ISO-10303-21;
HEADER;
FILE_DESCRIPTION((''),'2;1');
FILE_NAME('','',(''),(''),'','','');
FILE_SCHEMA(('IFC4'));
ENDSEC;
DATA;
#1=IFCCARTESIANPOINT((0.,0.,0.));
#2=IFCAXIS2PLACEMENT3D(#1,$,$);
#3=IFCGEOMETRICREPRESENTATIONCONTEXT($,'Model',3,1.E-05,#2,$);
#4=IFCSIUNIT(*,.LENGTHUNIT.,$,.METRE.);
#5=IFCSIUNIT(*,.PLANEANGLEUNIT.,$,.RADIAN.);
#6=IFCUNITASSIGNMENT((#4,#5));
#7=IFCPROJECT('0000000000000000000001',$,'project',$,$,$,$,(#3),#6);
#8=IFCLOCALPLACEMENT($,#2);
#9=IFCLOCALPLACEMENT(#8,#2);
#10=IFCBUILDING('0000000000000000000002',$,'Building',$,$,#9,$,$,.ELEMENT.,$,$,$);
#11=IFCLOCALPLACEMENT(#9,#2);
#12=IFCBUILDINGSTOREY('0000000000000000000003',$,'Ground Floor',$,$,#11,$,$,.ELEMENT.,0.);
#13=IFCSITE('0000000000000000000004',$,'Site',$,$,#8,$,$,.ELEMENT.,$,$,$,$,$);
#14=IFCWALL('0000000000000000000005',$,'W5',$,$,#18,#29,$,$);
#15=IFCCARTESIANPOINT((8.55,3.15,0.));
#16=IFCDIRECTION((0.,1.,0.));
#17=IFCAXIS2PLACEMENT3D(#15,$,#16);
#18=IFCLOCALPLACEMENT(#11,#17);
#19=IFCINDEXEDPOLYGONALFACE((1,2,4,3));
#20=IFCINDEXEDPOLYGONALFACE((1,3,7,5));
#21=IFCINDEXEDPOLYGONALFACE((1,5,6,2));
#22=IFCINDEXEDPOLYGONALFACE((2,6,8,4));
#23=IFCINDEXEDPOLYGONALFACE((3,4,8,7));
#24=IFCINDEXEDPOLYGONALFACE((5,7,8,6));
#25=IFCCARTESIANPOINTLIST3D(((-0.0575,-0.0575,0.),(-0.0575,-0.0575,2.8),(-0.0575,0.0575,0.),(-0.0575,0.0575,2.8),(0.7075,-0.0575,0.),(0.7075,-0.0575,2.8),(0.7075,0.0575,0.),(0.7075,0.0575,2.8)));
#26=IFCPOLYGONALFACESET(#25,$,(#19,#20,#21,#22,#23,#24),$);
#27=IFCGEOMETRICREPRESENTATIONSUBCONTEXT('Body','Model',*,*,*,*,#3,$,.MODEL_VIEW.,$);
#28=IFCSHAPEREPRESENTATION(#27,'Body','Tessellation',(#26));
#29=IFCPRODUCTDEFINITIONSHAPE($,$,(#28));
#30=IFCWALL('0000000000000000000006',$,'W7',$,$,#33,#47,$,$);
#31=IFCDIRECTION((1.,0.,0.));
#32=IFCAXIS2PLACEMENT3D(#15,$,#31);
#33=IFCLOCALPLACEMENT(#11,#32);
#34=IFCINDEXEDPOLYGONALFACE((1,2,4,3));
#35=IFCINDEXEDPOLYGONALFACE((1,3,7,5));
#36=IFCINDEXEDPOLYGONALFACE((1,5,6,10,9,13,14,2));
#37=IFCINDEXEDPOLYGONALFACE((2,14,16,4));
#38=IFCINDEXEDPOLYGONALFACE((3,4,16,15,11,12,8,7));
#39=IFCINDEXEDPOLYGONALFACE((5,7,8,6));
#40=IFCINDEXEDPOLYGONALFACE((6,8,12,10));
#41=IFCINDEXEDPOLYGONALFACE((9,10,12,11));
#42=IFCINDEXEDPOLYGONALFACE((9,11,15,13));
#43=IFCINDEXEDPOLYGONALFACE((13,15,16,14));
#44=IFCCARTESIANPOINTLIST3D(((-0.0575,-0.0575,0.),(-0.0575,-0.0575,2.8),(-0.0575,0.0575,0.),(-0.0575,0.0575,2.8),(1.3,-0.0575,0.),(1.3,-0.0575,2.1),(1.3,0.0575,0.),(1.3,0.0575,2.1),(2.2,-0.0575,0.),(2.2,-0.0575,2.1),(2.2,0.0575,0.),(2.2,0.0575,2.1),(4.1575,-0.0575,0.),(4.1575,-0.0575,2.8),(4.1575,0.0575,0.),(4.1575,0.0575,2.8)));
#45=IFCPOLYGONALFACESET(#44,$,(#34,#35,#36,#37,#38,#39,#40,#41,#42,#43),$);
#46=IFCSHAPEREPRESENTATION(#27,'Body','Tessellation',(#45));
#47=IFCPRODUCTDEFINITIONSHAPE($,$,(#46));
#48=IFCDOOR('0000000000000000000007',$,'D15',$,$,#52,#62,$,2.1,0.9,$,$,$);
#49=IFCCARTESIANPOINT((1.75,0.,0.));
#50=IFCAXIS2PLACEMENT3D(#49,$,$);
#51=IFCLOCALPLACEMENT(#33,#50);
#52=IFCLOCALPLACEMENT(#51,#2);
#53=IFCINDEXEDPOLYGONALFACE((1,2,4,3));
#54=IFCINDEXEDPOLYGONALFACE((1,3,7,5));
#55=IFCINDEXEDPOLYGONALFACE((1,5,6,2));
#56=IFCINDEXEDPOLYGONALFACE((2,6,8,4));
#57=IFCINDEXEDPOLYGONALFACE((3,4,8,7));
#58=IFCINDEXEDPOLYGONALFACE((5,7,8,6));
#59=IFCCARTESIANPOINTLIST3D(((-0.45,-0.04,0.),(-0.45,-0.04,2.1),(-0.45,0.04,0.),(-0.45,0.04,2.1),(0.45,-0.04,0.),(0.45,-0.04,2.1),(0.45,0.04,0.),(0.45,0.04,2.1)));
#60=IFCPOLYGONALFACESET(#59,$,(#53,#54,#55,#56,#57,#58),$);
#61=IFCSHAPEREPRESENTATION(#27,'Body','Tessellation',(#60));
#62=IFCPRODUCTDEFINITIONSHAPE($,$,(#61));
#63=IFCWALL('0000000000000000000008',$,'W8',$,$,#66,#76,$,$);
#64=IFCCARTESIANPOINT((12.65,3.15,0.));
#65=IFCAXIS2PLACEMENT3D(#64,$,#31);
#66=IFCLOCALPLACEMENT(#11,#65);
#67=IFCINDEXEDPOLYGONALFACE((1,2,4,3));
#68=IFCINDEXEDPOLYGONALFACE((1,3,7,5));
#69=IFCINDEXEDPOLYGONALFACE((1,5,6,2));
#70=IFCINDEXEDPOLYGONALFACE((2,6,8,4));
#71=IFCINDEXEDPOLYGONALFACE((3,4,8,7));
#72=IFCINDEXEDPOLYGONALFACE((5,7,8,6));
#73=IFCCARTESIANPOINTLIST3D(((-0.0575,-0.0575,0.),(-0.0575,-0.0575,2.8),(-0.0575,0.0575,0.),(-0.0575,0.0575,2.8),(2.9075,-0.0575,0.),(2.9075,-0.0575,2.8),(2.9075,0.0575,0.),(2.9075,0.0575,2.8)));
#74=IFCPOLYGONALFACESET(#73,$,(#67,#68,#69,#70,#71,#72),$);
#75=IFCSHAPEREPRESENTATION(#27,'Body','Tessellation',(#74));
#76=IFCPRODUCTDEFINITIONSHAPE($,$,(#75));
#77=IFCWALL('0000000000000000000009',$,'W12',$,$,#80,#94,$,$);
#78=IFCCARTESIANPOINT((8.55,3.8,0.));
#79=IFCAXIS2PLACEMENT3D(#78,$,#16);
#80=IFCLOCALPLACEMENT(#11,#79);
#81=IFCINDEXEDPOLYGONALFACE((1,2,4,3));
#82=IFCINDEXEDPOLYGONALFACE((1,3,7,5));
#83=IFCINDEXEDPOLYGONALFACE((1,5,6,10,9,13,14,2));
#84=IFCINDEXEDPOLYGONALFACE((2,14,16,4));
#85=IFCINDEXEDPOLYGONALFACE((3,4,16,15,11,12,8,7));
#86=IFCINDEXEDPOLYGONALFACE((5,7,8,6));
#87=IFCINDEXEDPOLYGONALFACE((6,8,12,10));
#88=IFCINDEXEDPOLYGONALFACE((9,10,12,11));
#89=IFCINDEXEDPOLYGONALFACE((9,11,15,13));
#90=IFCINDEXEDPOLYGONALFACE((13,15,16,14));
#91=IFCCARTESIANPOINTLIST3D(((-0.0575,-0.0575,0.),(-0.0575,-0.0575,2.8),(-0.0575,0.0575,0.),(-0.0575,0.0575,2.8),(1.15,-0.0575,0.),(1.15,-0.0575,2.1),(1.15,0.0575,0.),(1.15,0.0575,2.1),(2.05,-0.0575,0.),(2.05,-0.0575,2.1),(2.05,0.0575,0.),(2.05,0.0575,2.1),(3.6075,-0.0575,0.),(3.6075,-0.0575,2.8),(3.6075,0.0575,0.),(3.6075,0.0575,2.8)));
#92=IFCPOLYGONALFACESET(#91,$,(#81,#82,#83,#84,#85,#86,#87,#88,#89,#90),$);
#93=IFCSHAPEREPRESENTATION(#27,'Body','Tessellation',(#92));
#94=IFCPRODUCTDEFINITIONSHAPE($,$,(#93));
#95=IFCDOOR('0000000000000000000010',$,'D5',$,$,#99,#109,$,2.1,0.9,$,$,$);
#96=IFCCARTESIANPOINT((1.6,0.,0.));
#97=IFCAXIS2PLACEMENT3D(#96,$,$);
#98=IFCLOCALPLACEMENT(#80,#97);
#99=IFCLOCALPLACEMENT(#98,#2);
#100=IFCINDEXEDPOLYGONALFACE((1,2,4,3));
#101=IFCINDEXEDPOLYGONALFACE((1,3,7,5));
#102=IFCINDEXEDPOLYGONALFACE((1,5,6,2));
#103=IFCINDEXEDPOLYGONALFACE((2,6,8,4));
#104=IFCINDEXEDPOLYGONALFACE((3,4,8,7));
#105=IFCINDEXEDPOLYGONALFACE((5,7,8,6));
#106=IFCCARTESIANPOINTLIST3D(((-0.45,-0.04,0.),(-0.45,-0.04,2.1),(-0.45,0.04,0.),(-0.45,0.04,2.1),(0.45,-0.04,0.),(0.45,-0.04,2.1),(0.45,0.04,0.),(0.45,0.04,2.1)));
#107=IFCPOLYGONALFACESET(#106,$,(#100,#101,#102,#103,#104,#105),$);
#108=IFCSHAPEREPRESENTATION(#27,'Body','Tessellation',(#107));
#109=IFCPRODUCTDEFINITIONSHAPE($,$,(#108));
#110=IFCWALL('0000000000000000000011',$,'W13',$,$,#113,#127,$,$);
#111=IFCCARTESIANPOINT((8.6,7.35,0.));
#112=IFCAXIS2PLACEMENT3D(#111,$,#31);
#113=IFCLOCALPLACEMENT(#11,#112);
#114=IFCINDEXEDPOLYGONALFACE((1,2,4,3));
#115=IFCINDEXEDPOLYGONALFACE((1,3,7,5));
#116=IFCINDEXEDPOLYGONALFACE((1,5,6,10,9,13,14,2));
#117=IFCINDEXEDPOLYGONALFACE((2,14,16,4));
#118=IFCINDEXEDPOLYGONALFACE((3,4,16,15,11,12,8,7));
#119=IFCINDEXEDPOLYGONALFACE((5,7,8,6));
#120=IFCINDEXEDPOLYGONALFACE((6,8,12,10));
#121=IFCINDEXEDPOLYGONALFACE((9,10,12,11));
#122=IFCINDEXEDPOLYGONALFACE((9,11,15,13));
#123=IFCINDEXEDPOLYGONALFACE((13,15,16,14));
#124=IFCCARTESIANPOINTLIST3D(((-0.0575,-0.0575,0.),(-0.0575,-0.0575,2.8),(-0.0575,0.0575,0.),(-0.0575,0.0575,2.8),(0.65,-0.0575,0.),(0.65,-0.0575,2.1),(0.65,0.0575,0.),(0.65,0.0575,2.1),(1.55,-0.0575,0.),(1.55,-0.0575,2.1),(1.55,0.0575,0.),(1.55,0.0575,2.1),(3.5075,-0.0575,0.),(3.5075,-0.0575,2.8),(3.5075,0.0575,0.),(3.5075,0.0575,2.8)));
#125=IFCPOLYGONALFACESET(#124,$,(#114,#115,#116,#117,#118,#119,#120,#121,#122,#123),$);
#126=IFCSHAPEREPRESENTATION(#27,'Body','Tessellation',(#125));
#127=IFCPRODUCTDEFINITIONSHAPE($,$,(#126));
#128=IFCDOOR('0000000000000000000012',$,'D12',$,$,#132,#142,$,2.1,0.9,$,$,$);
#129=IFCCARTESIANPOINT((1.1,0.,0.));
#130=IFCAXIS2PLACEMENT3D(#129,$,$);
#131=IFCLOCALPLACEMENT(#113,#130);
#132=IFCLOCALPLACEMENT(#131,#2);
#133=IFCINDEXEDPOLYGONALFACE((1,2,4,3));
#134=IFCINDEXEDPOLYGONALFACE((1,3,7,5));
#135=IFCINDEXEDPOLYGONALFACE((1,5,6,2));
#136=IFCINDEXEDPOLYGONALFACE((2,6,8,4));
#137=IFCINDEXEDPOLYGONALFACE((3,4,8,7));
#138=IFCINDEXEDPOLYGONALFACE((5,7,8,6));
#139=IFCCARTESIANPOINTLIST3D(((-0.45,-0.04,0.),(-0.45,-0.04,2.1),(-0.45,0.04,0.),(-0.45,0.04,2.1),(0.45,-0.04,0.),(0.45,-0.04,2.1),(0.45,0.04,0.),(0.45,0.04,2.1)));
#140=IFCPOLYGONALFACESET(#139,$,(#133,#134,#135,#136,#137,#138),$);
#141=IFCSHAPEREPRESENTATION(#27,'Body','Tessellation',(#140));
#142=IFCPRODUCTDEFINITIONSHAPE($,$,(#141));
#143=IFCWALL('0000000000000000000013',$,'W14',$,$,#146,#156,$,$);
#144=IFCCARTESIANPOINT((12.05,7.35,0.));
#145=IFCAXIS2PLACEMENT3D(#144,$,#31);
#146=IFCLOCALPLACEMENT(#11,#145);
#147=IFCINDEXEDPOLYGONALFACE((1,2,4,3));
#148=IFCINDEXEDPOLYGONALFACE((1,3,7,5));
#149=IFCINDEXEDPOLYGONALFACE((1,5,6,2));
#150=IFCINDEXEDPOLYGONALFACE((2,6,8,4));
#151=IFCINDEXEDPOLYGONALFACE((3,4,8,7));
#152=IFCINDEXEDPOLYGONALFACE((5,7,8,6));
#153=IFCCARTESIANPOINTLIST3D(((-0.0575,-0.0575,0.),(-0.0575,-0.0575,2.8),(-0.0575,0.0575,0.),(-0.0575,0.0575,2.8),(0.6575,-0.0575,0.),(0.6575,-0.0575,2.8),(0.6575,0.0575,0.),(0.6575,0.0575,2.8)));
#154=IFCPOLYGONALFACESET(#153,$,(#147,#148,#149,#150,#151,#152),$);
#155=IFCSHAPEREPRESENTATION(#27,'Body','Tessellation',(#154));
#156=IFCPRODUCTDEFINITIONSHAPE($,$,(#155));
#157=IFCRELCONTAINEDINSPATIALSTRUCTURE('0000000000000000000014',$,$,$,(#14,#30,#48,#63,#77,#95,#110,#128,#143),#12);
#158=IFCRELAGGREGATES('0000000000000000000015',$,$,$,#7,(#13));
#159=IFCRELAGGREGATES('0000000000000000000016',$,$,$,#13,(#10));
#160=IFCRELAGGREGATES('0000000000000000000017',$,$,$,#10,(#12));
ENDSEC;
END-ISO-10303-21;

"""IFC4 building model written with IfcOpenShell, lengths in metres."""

from ifc_helpers import new_model, si_unit, frame, frame_2d, origin, origin_2d, place, context, subcontext, project, spatial, rectangle, extrude, element, fill, save


model = new_model("IFC4")

# Units and contexts
model_context = context("Model", 3, precision=1e-05, world=origin())
body_context = subcontext(model_context, "Body", "Model", "MODEL_VIEW")
ifc_project = project(units=[si_unit("LENGTHUNIT", "METRE"), si_unit("PLANEANGLEUNIT", "RADIAN")], contexts=[model_context])

# Site, building, storey
site_placement = place(None, origin())
site = spatial("IfcSite", under=ifc_project, at=site_placement, Name="Site", CompositionType="ELEMENT")
building_placement = place(site_placement, origin())
building = spatial("IfcBuilding", under=site, at=building_placement, Name="Building", CompositionType="ELEMENT")
storey_placement = place(building_placement, origin())
storey = spatial("IfcBuildingStorey", under=building, at=storey_placement, Name="Ground Floor", CompositionType="ELEMENT", Elevation=0.0)

# Wall
wall_1_placement = place(storey_placement, frame((8.55, 3.15, 0.0), x_axis=(0.0, 1.0, 0.0)))
element("IfcWall", 1, at=wall_1_placement, inside=storey, Name="W5", context=body_context, shape_type="SweptSolid", body=[
    extrude(rectangle(XDim=0.765, YDim=0.115, at=frame_2d((0.325, 0.0))), origin(), (0.0, 0.0, 1.0), 2.8),
])

# Wall, opening, door
wall_2_placement = place(storey_placement, frame((8.55, 3.15, 0.0), x_axis=(1.0, 0.0, 0.0)))
wall_2 = element("IfcWall", 2, at=wall_2_placement, inside=storey, Name="W7", context=body_context, shape_type="SweptSolid", body=[
    extrude(rectangle(XDim=4.215, YDim=0.115, at=frame_2d((2.05, 0.0))), origin(), (0.0, 0.0, 1.0), 2.8),
])
opening_1_placement = place(wall_2_placement, frame((1.75, 0.0, 0.0)))
opening_1 = element("IfcOpeningElement", 3, at=opening_1_placement, cuts=wall_2, context=body_context, shape_type="SweptSolid", body=[
    extrude(rectangle(XDim=0.9, YDim=0.215, at=origin_2d()), origin(), (0.0, 0.0, 1.0), 2.1),
])
door_1_placement = place(opening_1_placement, origin())
door_1 = element("IfcDoor", 4, at=door_1_placement, inside=storey, Name="D15", OverallHeight=2.1, OverallWidth=0.9, context=body_context, shape_type="SweptSolid", body=[
    extrude(rectangle(XDim=0.9, YDim=0.08, at=origin_2d()), origin(), (0.0, 0.0, 1.0), 2.1),
])
fill(opening_1, door_1)

# Wall
wall_3_placement = place(storey_placement, frame((12.65, 3.15, 0.0), x_axis=(1.0, 0.0, 0.0)))
element("IfcWall", 5, at=wall_3_placement, inside=storey, Name="W8", context=body_context, shape_type="SweptSolid", body=[
    extrude(rectangle(XDim=2.965, YDim=0.115, at=frame_2d((1.425, 0.0))), origin(), (0.0, 0.0, 1.0), 2.8),
])

# Walls, openings, doors
wall_4_placement = place(storey_placement, frame((8.55, 3.8, 0.0), x_axis=(0.0, 1.0, 0.0)))
wall_4 = element("IfcWall", 6, at=wall_4_placement, inside=storey, Name="W12", context=body_context, shape_type="SweptSolid", body=[
    extrude(rectangle(XDim=3.665, YDim=0.115, at=frame_2d((1.775, 0.0))), origin(), (0.0, 0.0, 1.0), 2.8),
])
opening_2_placement = place(wall_4_placement, frame((1.6, 0.0, 0.0)))
opening_2 = element("IfcOpeningElement", 7, at=opening_2_placement, cuts=wall_4, context=body_context, shape_type="SweptSolid", body=[
    extrude(rectangle(XDim=0.9, YDim=0.215, at=origin_2d()), origin(), (0.0, 0.0, 1.0), 2.1),
])
door_2_placement = place(opening_2_placement, origin())
door_2 = element("IfcDoor", 8, at=door_2_placement, inside=storey, Name="D5", OverallHeight=2.1, OverallWidth=0.9, context=body_context, shape_type="SweptSolid", body=[
    extrude(rectangle(XDim=0.9, YDim=0.08, at=origin_2d()), origin(), (0.0, 0.0, 1.0), 2.1),
])
fill(opening_2, door_2)
wall_5_placement = place(storey_placement, frame((8.6, 7.35, 0.0), x_axis=(1.0, 0.0, 0.0)))
wall_5 = element("IfcWall", 9, at=wall_5_placement, inside=storey, Name="W13", context=body_context, shape_type="SweptSolid", body=[
    extrude(rectangle(XDim=3.565, YDim=0.115, at=frame_2d((1.725, 0.0))), origin(), (0.0, 0.0, 1.0), 2.8),
])
opening_3_placement = place(wall_5_placement, frame((1.1, 0.0, 0.0)))
opening_3 = element("IfcOpeningElement", 10, at=opening_3_placement, cuts=wall_5, context=body_context, shape_type="SweptSolid", body=[
    extrude(rectangle(XDim=0.9, YDim=0.215, at=origin_2d()), origin(), (0.0, 0.0, 1.0), 2.1),
])
door_3_placement = place(opening_3_placement, origin())
door_3 = element("IfcDoor", 11, at=door_3_placement, inside=storey, Name="D12", OverallHeight=2.1, OverallWidth=0.9, context=body_context, shape_type="SweptSolid", body=[
    extrude(rectangle(XDim=0.9, YDim=0.08, at=origin_2d()), origin(), (0.0, 0.0, 1.0), 2.1),
])
fill(opening_3, door_3)

# Wall
wall_6_placement = place(storey_placement, frame((12.05, 7.35, 0.0), x_axis=(1.0, 0.0, 0.0)))
element("IfcWall", 12, at=wall_6_placement, inside=storey, Name="W14", context=body_context, shape_type="SweptSolid", body=[
    extrude(rectangle(XDim=0.715, YDim=0.115, at=frame_2d((0.3, 0.0))), origin(), (0.0, 0.0, 1.0), 2.8),
])

save(model, "model.ifc")
